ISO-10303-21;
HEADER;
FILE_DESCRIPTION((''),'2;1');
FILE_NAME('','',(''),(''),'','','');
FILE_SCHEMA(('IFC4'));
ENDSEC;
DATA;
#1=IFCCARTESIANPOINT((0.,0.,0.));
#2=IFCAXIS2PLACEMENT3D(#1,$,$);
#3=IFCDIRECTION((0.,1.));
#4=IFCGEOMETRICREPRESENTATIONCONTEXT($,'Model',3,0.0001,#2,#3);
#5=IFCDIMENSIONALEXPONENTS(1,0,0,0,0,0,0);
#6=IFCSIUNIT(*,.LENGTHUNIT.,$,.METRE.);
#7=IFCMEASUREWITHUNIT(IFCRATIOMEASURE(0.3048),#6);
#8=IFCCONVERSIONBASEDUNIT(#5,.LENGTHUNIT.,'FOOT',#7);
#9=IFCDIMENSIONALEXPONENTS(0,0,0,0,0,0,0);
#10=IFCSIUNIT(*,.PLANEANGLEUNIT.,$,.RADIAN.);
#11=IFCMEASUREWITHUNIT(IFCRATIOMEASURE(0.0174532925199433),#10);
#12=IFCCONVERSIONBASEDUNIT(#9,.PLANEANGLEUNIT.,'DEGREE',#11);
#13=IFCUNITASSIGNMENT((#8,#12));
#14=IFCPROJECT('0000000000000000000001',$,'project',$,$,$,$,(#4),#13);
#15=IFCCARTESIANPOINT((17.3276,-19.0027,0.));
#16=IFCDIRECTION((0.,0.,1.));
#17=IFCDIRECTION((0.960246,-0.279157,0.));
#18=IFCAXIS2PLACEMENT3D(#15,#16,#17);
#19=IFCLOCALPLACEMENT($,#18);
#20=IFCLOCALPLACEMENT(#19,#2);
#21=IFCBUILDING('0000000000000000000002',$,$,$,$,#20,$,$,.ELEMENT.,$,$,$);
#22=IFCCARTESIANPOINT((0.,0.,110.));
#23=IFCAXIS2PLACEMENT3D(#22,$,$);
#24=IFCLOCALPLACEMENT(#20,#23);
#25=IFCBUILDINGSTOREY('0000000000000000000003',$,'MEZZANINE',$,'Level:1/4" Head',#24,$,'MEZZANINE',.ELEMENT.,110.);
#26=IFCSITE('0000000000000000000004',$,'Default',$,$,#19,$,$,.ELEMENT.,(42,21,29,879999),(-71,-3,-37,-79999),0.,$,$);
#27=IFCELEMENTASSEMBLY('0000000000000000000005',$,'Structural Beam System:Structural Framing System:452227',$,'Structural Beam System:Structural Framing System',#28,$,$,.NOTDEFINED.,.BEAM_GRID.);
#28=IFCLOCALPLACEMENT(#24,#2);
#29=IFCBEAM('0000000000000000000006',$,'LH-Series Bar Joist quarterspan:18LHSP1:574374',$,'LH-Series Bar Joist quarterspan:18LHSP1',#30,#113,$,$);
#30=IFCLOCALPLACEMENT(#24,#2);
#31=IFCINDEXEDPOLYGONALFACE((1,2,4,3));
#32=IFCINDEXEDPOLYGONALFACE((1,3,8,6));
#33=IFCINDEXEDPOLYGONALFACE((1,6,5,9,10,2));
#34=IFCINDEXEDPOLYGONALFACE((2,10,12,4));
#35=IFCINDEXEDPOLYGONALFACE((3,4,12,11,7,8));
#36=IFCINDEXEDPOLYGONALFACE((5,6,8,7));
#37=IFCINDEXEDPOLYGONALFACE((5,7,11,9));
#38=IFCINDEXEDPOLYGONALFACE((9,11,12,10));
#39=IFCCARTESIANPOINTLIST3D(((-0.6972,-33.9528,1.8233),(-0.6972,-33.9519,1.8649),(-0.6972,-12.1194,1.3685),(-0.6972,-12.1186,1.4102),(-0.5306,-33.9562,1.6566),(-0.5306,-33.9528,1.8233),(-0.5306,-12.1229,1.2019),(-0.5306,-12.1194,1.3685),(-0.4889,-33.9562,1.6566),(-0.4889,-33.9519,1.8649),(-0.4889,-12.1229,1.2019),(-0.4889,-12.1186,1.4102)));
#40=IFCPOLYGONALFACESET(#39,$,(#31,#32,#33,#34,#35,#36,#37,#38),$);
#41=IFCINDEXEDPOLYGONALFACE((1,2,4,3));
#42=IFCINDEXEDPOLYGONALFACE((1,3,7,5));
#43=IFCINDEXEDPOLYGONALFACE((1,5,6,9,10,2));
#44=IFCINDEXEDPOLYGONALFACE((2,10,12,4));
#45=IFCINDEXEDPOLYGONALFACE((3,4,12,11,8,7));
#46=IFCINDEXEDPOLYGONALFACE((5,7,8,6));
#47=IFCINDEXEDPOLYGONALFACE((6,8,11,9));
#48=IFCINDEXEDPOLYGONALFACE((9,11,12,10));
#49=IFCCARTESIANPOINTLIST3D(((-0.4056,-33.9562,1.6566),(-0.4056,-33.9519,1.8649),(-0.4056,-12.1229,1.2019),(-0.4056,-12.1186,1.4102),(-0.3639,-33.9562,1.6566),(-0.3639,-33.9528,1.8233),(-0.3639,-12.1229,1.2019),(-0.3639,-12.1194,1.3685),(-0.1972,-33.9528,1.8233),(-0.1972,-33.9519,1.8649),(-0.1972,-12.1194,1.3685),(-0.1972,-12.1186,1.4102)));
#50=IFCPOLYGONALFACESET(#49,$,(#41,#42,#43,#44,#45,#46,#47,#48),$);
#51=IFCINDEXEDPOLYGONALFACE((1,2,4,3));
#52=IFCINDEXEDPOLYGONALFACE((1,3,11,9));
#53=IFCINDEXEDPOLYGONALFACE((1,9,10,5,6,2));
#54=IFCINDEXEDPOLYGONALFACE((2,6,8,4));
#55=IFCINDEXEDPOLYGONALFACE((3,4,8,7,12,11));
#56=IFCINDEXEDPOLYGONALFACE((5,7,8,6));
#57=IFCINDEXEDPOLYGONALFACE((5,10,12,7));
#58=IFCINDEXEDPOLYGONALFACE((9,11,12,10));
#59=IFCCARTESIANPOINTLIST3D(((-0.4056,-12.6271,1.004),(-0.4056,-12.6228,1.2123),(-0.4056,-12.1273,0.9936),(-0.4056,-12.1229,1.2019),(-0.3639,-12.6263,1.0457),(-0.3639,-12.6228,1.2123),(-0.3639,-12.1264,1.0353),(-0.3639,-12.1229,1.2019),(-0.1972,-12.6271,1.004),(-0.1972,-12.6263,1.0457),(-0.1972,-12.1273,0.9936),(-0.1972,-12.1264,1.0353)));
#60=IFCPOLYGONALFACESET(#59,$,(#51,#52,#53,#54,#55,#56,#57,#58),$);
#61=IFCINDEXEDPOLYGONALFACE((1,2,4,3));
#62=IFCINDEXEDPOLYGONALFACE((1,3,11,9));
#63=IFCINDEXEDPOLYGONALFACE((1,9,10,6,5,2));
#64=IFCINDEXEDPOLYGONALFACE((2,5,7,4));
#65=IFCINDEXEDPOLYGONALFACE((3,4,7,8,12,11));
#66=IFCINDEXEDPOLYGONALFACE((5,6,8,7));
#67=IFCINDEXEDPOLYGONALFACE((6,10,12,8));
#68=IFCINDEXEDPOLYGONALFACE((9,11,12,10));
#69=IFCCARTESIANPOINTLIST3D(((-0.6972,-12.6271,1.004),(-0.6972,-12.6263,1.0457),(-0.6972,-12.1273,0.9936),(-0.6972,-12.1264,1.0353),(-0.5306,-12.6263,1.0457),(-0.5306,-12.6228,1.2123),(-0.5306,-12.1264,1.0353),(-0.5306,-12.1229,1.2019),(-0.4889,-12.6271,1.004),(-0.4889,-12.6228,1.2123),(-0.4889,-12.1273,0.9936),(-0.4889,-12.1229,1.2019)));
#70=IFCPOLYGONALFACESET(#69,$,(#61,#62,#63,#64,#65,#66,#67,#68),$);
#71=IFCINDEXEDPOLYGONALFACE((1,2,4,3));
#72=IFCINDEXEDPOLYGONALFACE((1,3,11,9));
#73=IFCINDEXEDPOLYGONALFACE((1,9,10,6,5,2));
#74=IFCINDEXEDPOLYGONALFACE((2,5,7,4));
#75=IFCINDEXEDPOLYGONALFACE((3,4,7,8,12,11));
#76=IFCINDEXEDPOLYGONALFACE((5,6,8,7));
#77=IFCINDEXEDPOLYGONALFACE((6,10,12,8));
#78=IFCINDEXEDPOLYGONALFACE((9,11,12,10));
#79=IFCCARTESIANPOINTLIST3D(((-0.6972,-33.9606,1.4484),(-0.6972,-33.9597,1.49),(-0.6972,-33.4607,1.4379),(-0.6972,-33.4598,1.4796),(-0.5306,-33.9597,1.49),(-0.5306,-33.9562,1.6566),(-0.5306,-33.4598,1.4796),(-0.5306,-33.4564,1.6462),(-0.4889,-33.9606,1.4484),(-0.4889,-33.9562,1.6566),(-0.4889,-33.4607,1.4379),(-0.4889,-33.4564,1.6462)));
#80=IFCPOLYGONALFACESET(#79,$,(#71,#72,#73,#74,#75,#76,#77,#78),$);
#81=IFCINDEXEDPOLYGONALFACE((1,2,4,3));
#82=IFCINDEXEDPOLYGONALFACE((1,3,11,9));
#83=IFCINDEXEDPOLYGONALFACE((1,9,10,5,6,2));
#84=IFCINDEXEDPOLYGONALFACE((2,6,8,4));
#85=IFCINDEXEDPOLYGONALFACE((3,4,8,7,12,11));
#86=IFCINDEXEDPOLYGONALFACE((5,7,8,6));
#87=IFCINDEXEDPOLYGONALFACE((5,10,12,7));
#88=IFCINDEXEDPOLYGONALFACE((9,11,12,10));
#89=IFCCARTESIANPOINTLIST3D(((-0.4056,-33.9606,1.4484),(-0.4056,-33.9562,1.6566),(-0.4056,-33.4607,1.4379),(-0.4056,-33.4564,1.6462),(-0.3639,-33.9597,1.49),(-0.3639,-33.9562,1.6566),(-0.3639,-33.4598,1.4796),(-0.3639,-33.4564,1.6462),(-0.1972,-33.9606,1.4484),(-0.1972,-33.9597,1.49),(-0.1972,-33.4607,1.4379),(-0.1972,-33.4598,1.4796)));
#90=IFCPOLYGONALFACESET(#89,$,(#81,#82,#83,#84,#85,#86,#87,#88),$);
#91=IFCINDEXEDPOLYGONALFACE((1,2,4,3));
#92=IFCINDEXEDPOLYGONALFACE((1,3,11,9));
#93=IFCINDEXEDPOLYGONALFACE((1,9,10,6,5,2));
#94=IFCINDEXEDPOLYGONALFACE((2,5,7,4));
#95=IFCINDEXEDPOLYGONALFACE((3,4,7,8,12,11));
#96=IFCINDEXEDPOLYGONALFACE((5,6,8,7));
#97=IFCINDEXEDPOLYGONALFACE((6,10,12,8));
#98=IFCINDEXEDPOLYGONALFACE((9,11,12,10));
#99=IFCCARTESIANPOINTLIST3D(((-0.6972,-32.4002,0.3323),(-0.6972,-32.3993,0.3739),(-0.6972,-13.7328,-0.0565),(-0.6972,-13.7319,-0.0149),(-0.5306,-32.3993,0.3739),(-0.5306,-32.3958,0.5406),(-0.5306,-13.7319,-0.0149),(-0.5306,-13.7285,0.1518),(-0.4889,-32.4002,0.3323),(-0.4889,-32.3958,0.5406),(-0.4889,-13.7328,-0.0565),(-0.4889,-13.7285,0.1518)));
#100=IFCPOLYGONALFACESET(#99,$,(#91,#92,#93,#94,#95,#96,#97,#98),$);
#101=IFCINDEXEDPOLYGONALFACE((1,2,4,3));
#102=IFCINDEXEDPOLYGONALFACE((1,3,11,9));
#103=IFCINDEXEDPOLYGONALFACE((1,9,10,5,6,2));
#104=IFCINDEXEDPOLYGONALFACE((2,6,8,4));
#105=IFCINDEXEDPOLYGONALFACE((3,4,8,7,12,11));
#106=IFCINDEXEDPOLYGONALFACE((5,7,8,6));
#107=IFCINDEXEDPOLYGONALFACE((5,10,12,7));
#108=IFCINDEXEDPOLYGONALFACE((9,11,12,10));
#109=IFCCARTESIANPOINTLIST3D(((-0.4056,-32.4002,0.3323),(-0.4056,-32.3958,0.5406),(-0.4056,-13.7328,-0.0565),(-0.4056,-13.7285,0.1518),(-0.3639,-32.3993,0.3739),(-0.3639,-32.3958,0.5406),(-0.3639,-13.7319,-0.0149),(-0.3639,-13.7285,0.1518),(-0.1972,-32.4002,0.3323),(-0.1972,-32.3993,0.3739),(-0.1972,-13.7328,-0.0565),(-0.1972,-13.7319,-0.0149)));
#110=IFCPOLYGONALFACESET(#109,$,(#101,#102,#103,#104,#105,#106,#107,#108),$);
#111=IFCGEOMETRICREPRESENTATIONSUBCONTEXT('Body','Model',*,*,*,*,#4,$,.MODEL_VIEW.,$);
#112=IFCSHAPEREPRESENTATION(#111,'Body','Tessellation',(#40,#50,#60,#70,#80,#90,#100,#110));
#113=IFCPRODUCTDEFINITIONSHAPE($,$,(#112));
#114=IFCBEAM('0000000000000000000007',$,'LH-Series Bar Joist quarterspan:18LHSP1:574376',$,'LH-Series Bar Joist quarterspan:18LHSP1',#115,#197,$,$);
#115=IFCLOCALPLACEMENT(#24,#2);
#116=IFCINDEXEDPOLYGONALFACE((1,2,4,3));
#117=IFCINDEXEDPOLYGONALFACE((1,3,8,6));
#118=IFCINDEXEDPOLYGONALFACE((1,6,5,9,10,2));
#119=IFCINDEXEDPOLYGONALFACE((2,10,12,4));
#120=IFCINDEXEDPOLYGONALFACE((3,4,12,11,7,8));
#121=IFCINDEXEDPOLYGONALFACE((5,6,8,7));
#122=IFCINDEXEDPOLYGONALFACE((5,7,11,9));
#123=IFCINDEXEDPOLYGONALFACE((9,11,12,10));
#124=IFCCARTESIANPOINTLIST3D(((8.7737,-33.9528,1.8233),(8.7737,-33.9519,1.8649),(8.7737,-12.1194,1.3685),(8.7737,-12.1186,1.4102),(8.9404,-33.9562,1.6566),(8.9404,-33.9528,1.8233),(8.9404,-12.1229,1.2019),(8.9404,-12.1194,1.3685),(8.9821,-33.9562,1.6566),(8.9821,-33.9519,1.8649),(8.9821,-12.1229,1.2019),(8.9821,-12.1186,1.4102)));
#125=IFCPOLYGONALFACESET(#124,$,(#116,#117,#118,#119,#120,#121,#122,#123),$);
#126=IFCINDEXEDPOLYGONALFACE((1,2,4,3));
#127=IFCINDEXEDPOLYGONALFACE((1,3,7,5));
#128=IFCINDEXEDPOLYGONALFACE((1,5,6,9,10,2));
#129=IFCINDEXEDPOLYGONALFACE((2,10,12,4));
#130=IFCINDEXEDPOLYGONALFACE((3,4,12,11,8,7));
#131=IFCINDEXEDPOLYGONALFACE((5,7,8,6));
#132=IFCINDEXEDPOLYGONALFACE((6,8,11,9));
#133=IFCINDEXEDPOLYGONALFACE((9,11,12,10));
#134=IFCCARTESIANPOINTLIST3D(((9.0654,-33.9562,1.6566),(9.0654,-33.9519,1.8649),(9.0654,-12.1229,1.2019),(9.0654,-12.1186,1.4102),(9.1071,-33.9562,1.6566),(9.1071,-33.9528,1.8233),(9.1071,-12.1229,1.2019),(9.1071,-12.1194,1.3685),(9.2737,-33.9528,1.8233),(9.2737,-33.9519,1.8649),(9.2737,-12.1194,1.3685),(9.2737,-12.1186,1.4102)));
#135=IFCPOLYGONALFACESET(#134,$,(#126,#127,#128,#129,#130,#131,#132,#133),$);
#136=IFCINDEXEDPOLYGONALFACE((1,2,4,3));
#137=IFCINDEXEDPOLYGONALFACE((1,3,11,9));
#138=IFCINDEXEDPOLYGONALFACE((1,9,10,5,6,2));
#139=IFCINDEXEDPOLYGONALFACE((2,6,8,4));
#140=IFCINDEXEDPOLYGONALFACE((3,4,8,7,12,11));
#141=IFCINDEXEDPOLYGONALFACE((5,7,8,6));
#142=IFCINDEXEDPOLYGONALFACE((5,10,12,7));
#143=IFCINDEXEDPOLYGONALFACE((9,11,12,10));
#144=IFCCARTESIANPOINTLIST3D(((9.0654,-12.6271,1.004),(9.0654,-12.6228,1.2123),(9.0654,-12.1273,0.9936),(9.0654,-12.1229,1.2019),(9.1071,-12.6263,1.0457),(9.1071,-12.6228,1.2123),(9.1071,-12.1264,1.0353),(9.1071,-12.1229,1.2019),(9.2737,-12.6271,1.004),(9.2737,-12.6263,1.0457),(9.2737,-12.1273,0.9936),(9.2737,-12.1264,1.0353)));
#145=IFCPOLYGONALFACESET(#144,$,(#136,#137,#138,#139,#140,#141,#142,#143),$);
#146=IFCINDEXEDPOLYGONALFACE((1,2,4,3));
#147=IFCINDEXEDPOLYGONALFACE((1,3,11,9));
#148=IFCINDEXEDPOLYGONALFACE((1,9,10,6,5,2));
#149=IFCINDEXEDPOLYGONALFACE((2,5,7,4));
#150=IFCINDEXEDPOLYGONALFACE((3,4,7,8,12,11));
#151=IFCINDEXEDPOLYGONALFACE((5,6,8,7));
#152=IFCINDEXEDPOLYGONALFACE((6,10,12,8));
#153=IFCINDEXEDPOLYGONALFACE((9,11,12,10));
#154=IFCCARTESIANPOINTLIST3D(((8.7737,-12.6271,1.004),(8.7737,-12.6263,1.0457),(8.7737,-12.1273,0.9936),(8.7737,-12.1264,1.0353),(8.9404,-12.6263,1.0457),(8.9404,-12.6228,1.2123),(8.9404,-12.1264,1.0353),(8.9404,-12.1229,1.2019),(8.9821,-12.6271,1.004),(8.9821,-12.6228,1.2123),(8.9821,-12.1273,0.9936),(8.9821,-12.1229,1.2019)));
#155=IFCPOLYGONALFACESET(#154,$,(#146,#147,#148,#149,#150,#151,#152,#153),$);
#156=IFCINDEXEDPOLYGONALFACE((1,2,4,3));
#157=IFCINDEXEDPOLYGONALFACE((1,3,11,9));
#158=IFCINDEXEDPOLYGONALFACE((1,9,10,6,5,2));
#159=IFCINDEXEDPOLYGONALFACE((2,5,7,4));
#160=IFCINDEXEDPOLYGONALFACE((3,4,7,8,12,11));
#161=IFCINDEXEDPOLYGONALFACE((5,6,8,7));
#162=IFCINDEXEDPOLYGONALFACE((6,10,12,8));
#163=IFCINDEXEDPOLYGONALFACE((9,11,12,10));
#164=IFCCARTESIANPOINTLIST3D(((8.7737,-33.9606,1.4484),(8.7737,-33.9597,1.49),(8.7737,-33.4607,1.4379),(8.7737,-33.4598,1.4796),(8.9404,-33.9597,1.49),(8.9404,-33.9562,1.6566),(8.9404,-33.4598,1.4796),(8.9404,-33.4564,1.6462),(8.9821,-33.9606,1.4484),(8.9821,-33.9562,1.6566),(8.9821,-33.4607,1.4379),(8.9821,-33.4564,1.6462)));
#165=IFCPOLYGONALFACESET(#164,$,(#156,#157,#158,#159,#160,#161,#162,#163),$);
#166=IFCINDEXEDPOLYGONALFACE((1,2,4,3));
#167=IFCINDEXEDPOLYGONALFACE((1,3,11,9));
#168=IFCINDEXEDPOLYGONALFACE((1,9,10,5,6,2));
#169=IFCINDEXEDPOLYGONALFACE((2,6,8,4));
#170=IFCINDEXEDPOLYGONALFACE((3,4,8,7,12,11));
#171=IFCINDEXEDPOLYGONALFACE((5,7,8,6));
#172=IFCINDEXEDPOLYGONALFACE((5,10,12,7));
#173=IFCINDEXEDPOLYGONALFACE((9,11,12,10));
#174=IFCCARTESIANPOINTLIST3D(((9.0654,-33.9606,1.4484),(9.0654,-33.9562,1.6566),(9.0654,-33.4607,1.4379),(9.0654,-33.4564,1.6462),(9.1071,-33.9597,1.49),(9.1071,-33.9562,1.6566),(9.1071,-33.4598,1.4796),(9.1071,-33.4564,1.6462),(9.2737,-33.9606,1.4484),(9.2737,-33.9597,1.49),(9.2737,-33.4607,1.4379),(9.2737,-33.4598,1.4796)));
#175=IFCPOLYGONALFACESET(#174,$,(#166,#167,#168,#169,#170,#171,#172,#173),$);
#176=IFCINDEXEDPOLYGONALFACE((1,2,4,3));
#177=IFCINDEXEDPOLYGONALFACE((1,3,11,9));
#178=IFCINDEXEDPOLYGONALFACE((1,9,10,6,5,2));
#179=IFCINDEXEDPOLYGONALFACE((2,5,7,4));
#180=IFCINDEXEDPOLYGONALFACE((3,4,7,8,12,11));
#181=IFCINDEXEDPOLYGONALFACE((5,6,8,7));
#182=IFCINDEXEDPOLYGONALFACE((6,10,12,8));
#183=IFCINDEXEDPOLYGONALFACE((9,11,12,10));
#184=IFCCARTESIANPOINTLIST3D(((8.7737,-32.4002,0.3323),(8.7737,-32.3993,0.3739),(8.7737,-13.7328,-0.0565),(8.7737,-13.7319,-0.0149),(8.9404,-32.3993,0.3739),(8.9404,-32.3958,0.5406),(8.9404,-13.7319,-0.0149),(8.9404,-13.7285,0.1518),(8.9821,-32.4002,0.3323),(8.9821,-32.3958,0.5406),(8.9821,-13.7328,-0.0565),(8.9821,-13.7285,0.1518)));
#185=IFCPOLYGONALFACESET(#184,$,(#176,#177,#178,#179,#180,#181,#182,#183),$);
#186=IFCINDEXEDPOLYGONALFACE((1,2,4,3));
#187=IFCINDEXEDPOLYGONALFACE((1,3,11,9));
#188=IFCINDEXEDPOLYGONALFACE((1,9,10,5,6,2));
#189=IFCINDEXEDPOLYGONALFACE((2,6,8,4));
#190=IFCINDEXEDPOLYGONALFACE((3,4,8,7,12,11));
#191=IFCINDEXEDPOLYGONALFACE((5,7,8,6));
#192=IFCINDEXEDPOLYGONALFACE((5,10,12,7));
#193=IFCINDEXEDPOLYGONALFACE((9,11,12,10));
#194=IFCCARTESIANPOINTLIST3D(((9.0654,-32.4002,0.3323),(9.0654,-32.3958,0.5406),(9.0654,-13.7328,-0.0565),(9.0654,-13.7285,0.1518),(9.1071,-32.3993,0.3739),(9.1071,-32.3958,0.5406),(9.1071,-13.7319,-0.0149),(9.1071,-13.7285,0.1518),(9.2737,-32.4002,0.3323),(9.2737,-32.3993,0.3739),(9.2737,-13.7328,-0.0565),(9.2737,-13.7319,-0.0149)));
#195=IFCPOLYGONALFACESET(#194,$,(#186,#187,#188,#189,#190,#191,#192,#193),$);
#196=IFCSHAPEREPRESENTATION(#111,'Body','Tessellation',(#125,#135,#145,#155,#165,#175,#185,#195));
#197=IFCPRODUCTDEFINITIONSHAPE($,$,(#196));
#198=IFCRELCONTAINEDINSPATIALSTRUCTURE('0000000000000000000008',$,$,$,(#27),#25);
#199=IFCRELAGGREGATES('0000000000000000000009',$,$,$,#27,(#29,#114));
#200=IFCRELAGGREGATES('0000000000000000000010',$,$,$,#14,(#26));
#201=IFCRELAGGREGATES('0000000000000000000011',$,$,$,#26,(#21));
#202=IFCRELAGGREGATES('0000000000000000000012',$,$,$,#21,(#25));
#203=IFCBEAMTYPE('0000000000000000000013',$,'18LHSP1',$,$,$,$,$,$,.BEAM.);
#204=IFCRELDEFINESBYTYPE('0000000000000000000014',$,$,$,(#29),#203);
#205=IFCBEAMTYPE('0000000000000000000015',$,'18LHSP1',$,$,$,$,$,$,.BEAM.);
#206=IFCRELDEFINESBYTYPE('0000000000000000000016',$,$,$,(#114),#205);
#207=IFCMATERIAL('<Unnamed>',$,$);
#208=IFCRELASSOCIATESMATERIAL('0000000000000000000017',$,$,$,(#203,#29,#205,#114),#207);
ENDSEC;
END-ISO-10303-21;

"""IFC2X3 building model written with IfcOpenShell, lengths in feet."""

from ifc_helpers import new_model, entity, si_unit, converted_unit, direction, frame, origin, place, context, subcontext, project, spatial, polyline, outline, extrude, source, transform, mapped, material, type_object, type_shapes, element, aggregate, save


model = new_model("IFC2X3")

# Units and contexts
model_context = context("Model", 3, precision=0.0001, world=origin(), true_north=direction((0.0, 1.0)))
body_context = subcontext(model_context, "Body", "Model", "MODEL_VIEW")
ifc_project = project(units=[converted_unit("LENGTHUNIT", "FOOT", entity("IfcRatioMeasure", 0.3048), si_unit("LENGTHUNIT", "METRE"), dimensions=[1, 0, 0, 0, 0, 0, 0]), converted_unit("PLANEANGLEUNIT", "DEGREE", entity("IfcRatioMeasure", 0.0174532925199433), si_unit("PLANEANGLEUNIT", "RADIAN"), dimensions=[0, 0, 0, 0, 0, 0, 0])], contexts=[model_context])

# Site, building, storey
site_placement = place(None, frame((17.3276, -19.0027, 0.0), z_axis=(0.0, 0.0, 1.0), x_axis=(0.960246, -0.279157, 0.0)))
site = spatial("IfcSite", under=ifc_project, at=site_placement, Name="Default", CompositionType="ELEMENT", RefLatitude=(42, 21, 29, 879999), RefLongitude=(-71, -3, -37, -79999), RefElevation=0.0)
building_placement = place(site_placement, origin())
building = spatial("IfcBuilding", under=site, at=building_placement, CompositionType="ELEMENT")
storey_placement = place(building_placement, frame((0.0, 0.0, 110.0)))
storey = spatial("IfcBuildingStorey", under=building, at=storey_placement, Name="MEZZANINE", ObjectType="Level:1/4\" Head", LongName="MEZZANINE", CompositionType="ELEMENT", Elevation=110.0)

# Element assembly, beams
assembly_1_placement = place(storey_placement, origin())
assembly_1 = element("IfcElementAssembly", 1, at=assembly_1_placement, inside=storey, Name="Structural Beam System:Structural Framing System:452227", ObjectType="Structural Beam System:Structural Framing System", AssemblyPlace="NOTDEFINED", PredefinedType="BEAM_GRID")
ifc_material_1 = material(Name="<Unnamed>")
beam_type_1 = type_object("IfcBeamType", Name="18LHSP1", PredefinedType="BEAM", material=ifc_material_1)
shared_shape_1 = source(origin(), body_context, "Body", "SweptSolid", [
    extrude(outline(polyline([(-0.0833, -0.125), (-0.0417, -0.125), (-0.0417, 0.0417), (0.125, 0.0417), (0.125, 0.0833), (-0.0833, 0.0833), (-0.0833, -0.125)])), frame((-10.919, -0.125, 0.6667), z_axis=(1.0, 0.0, 0.0), x_axis=(0.0, 0.0, -1.0)), (0.0, 0.0, 1.0), 21.8381),
    extrude(outline(polyline([(-0.0833, -0.0833), (0.125, -0.0833), (0.125, -0.0417), (-0.0417, -0.0417), (-0.0417, 0.125), (-0.0833, 0.125), (-0.0833, -0.0833)])), frame((-10.919, 0.125, 0.6667), z_axis=(1.0, 0.0, 0.0), x_axis=(0.0, 0.0, -1.0)), (0.0, 0.0, 1.0), 21.8381),
    extrude(outline(polyline([(-0.125, -0.0833), (0.0833, -0.0833), (0.0833, 0.125), (0.0417, 0.125), (0.0417, -0.0417), (-0.125, -0.0417), (-0.125, -0.0833)])), frame((-10.919, 0.125, 0.4167), z_axis=(1.0, 0.0, 0.0), x_axis=(0.0, 0.0, -1.0)), (0.0, 0.0, 1.0), 0.5),
    extrude(outline(polyline([(0.0417, -0.125), (0.0833, -0.125), (0.0833, 0.0833), (-0.125, 0.0833), (-0.125, 0.0417), (0.0417, 0.0417), (0.0417, -0.125)])), frame((-10.919, -0.125, 0.4167), z_axis=(1.0, 0.0, 0.0), x_axis=(0.0, 0.0, -1.0)), (0.0, 0.0, 1.0), 0.5),
    extrude(outline(polyline([(0.0417, -0.125), (0.0833, -0.125), (0.0833, 0.0833), (-0.125, 0.0833), (-0.125, 0.0417), (0.0417, 0.0417), (0.0417, -0.125)])), frame((10.419, -0.125, 0.4167), z_axis=(1.0, 0.0, 0.0), x_axis=(0.0, 0.0, -1.0)), (0.0, 0.0, 1.0), 0.5),
    extrude(outline(polyline([(-0.125, -0.0833), (0.0833, -0.0833), (0.0833, 0.125), (0.0417, 0.125), (0.0417, -0.0417), (-0.125, -0.0417), (-0.125, -0.0833)])), frame((10.419, 0.125, 0.4167), z_axis=(1.0, 0.0, 0.0), x_axis=(0.0, 0.0, -1.0)), (0.0, 0.0, 1.0), 0.5),
    extrude(outline(polyline([(0.0417, -0.125), (0.0833, -0.125), (0.0833, 0.0833), (-0.125, 0.0833), (-0.125, 0.0417), (0.0417, 0.0417), (0.0417, -0.125)])), frame((-9.3357, -0.125, -0.6667), z_axis=(1.0, 0.0, 0.0), x_axis=(0.0, 0.0, -1.0)), (0.0, 0.0, 1.0), 18.6714),
    extrude(outline(polyline([(-0.125, -0.0833), (0.0833, -0.0833), (0.0833, 0.125), (0.0417, 0.125), (0.0417, -0.0417), (-0.125, -0.0417), (-0.125, -0.0833)])), frame((-9.3357, 0.125, -0.6667), z_axis=(1.0, 0.0, 0.0), x_axis=(0.0, 0.0, -1.0)), (0.0, 0.0, 1.0), 18.6714),
])
type_shapes(beam_type_1, [shared_shape_1])
beam_1_placement = place(assembly_1_placement, frame((-0.4472, -23.0509, 0.8877), z_axis=(0.0, 0.020824, 0.999783), x_axis=(0.0, -0.999783, 0.020824)))
beam_1 = element("IfcBeam", 2, at=beam_1_placement, type_object=beam_type_1, material=ifc_material_1, Name="LH-Series Bar Joist quarterspan:18LHSP1:574374", ObjectType="LH-Series Bar Joist quarterspan:18LHSP1", context=body_context, shape_type="MappedRepresentation", body=[
    mapped(shared_shape_1, transform((0.0, 0.0, 0.0), scale=1.0)),
])
beam_type_2 = type_object("IfcBeamType", Name="18LHSP1", PredefinedType="BEAM", material=ifc_material_1)
shared_shape_2 = source(origin(), body_context, "Body", "SweptSolid", [
    extrude(outline(polyline([(-0.0833, -0.125), (-0.0417, -0.125), (-0.0417, 0.0417), (0.125, 0.0417), (0.125, 0.0833), (-0.0833, 0.0833), (-0.0833, -0.125)])), frame((-10.919, -0.125, 0.6667), z_axis=(1.0, 0.0, 0.0), x_axis=(0.0, 0.0, -1.0)), (0.0, 0.0, 1.0), 21.8381),
    extrude(outline(polyline([(-0.0833, -0.0833), (0.125, -0.0833), (0.125, -0.0417), (-0.0417, -0.0417), (-0.0417, 0.125), (-0.0833, 0.125), (-0.0833, -0.0833)])), frame((-10.919, 0.125, 0.6667), z_axis=(1.0, 0.0, 0.0), x_axis=(0.0, 0.0, -1.0)), (0.0, 0.0, 1.0), 21.8381),
    extrude(outline(polyline([(-0.125, -0.0833), (0.0833, -0.0833), (0.0833, 0.125), (0.0417, 0.125), (0.0417, -0.0417), (-0.125, -0.0417), (-0.125, -0.0833)])), frame((-10.919, 0.125, 0.4167), z_axis=(1.0, 0.0, 0.0), x_axis=(0.0, 0.0, -1.0)), (0.0, 0.0, 1.0), 0.5),
    extrude(outline(polyline([(0.0417, -0.125), (0.0833, -0.125), (0.0833, 0.0833), (-0.125, 0.0833), (-0.125, 0.0417), (0.0417, 0.0417), (0.0417, -0.125)])), frame((-10.919, -0.125, 0.4167), z_axis=(1.0, 0.0, 0.0), x_axis=(0.0, 0.0, -1.0)), (0.0, 0.0, 1.0), 0.5),
    extrude(outline(polyline([(0.0417, -0.125), (0.0833, -0.125), (0.0833, 0.0833), (-0.125, 0.0833), (-0.125, 0.0417), (0.0417, 0.0417), (0.0417, -0.125)])), frame((10.419, -0.125, 0.4167), z_axis=(1.0, 0.0, 0.0), x_axis=(0.0, 0.0, -1.0)), (0.0, 0.0, 1.0), 0.5),
    extrude(outline(polyline([(-0.125, -0.0833), (0.0833, -0.0833), (0.0833, 0.125), (0.0417, 0.125), (0.0417, -0.0417), (-0.125, -0.0417), (-0.125, -0.0833)])), frame((10.419, 0.125, 0.4167), z_axis=(1.0, 0.0, 0.0), x_axis=(0.0, 0.0, -1.0)), (0.0, 0.0, 1.0), 0.5),
    extrude(outline(polyline([(0.0417, -0.125), (0.0833, -0.125), (0.0833, 0.0833), (-0.125, 0.0833), (-0.125, 0.0417), (0.0417, 0.0417), (0.0417, -0.125)])), frame((-9.3357, -0.125, -0.6667), z_axis=(1.0, 0.0, 0.0), x_axis=(0.0, 0.0, -1.0)), (0.0, 0.0, 1.0), 18.6714),
    extrude(outline(polyline([(-0.125, -0.0833), (0.0833, -0.0833), (0.0833, 0.125), (0.0417, 0.125), (0.0417, -0.0417), (-0.125, -0.0417), (-0.125, -0.0833)])), frame((-9.3357, 0.125, -0.6667), z_axis=(1.0, 0.0, 0.0), x_axis=(0.0, 0.0, -1.0)), (0.0, 0.0, 1.0), 18.6714),
])
type_shapes(beam_type_2, [shared_shape_2])
beam_2_placement = place(assembly_1_placement, frame((9.0237, -23.0509, 0.8877), z_axis=(0.0, 0.020824, 0.999783), x_axis=(0.0, -0.999783, 0.020824)))
beam_2 = element("IfcBeam", 3, at=beam_2_placement, type_object=beam_type_2, material=ifc_material_1, Name="LH-Series Bar Joist quarterspan:18LHSP1:574376", ObjectType="LH-Series Bar Joist quarterspan:18LHSP1", context=body_context, shape_type="MappedRepresentation", body=[
    mapped(shared_shape_2, transform((0.0, 0.0, 0.0), scale=1.0)),
])
aggregate(assembly_1, [beam_1, beam_2])

save(model, "model.ifc")
